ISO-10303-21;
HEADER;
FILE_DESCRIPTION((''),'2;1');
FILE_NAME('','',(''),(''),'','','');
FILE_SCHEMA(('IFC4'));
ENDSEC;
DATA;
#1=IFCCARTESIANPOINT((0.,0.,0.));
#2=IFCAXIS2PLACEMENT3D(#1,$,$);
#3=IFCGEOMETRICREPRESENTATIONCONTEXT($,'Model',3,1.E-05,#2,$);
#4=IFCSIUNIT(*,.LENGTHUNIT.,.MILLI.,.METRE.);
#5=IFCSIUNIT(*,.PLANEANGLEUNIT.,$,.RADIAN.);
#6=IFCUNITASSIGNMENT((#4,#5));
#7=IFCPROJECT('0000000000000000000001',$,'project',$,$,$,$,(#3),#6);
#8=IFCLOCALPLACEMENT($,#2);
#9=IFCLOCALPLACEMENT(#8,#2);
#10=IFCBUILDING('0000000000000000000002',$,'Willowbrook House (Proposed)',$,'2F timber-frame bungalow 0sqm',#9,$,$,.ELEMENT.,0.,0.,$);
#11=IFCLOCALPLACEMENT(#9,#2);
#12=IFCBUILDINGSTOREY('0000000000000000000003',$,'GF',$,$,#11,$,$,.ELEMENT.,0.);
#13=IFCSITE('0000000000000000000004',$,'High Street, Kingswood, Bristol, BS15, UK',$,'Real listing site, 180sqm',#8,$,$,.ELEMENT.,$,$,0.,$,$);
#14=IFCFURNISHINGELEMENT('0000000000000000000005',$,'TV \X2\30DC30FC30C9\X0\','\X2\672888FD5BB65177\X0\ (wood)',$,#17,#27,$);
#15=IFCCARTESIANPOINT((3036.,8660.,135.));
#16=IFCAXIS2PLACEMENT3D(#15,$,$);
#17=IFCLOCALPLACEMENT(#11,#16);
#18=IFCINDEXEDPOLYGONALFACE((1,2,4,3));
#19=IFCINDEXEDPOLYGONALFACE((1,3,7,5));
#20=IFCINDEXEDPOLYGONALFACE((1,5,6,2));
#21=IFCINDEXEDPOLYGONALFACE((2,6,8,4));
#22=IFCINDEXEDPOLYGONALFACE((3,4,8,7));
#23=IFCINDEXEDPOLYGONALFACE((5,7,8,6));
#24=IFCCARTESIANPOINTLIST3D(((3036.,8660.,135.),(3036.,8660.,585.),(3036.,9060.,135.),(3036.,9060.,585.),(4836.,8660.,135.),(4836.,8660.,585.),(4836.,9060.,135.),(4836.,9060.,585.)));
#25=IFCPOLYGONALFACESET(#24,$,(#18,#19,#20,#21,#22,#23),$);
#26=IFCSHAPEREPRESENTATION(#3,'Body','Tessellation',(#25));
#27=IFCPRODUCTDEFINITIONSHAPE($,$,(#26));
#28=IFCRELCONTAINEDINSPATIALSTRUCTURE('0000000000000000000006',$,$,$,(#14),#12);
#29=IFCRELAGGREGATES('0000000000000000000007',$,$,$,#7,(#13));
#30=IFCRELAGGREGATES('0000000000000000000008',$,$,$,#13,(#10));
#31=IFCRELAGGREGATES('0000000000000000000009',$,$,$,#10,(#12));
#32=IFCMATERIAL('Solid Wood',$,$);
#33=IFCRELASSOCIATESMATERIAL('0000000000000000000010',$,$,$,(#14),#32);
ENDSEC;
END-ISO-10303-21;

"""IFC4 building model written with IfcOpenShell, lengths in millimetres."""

from ifc_helpers import new_model, si_unit, frame, frame_2d, origin, place, context, project, spatial, rectangle, extrude, material, element, save


model = new_model("IFC4")

# Units and contexts
model_context = context("Model", 3, precision=1e-05, world=origin())
ifc_project = project(units=[si_unit("LENGTHUNIT", "METRE", prefix="MILLI"), si_unit("PLANEANGLEUNIT", "RADIAN")], contexts=[model_context])

# Site, building, storey
site_placement = place(None, origin())
site = spatial("IfcSite", under=ifc_project, at=site_placement, Name="High Street, Kingswood, Bristol, BS15, UK", ObjectType="Real listing site, 180sqm", CompositionType="ELEMENT", RefElevation=0.0)
building_placement = place(site_placement, origin())
building = spatial("IfcBuilding", under=site, at=building_placement, Name="Willowbrook House (Proposed)", ObjectType="2F timber-frame bungalow 0sqm", CompositionType="ELEMENT", ElevationOfRefHeight=0.0, ElevationOfTerrain=0.0)
storey_placement = place(building_placement, origin())
storey = spatial("IfcBuildingStorey", under=building, at=storey_placement, Name="GF", CompositionType="ELEMENT", Elevation=0.0)

# Shared definitions
ifc_material_1 = material(Name="Solid Wood")

# Furnishing element
furnishing_placement = place(storey_placement, frame((3036.0, 8660.0, 135.0)))
element("IfcFurnishingElement", 1, at=furnishing_placement, inside=storey, material=ifc_material_1, Name="TV ボード", Description="木製家具 (wood)", context=model_context, shape_type="SweptSolid", body=[
    extrude(rectangle(XDim=1800.0, YDim=400.0, at=frame_2d((900.0, 200.0))), frame((3036.0, 8660.0, 135.0)), (0.0, 0.0, 1.0), 450.0),
])

save(model, "model.ifc")
